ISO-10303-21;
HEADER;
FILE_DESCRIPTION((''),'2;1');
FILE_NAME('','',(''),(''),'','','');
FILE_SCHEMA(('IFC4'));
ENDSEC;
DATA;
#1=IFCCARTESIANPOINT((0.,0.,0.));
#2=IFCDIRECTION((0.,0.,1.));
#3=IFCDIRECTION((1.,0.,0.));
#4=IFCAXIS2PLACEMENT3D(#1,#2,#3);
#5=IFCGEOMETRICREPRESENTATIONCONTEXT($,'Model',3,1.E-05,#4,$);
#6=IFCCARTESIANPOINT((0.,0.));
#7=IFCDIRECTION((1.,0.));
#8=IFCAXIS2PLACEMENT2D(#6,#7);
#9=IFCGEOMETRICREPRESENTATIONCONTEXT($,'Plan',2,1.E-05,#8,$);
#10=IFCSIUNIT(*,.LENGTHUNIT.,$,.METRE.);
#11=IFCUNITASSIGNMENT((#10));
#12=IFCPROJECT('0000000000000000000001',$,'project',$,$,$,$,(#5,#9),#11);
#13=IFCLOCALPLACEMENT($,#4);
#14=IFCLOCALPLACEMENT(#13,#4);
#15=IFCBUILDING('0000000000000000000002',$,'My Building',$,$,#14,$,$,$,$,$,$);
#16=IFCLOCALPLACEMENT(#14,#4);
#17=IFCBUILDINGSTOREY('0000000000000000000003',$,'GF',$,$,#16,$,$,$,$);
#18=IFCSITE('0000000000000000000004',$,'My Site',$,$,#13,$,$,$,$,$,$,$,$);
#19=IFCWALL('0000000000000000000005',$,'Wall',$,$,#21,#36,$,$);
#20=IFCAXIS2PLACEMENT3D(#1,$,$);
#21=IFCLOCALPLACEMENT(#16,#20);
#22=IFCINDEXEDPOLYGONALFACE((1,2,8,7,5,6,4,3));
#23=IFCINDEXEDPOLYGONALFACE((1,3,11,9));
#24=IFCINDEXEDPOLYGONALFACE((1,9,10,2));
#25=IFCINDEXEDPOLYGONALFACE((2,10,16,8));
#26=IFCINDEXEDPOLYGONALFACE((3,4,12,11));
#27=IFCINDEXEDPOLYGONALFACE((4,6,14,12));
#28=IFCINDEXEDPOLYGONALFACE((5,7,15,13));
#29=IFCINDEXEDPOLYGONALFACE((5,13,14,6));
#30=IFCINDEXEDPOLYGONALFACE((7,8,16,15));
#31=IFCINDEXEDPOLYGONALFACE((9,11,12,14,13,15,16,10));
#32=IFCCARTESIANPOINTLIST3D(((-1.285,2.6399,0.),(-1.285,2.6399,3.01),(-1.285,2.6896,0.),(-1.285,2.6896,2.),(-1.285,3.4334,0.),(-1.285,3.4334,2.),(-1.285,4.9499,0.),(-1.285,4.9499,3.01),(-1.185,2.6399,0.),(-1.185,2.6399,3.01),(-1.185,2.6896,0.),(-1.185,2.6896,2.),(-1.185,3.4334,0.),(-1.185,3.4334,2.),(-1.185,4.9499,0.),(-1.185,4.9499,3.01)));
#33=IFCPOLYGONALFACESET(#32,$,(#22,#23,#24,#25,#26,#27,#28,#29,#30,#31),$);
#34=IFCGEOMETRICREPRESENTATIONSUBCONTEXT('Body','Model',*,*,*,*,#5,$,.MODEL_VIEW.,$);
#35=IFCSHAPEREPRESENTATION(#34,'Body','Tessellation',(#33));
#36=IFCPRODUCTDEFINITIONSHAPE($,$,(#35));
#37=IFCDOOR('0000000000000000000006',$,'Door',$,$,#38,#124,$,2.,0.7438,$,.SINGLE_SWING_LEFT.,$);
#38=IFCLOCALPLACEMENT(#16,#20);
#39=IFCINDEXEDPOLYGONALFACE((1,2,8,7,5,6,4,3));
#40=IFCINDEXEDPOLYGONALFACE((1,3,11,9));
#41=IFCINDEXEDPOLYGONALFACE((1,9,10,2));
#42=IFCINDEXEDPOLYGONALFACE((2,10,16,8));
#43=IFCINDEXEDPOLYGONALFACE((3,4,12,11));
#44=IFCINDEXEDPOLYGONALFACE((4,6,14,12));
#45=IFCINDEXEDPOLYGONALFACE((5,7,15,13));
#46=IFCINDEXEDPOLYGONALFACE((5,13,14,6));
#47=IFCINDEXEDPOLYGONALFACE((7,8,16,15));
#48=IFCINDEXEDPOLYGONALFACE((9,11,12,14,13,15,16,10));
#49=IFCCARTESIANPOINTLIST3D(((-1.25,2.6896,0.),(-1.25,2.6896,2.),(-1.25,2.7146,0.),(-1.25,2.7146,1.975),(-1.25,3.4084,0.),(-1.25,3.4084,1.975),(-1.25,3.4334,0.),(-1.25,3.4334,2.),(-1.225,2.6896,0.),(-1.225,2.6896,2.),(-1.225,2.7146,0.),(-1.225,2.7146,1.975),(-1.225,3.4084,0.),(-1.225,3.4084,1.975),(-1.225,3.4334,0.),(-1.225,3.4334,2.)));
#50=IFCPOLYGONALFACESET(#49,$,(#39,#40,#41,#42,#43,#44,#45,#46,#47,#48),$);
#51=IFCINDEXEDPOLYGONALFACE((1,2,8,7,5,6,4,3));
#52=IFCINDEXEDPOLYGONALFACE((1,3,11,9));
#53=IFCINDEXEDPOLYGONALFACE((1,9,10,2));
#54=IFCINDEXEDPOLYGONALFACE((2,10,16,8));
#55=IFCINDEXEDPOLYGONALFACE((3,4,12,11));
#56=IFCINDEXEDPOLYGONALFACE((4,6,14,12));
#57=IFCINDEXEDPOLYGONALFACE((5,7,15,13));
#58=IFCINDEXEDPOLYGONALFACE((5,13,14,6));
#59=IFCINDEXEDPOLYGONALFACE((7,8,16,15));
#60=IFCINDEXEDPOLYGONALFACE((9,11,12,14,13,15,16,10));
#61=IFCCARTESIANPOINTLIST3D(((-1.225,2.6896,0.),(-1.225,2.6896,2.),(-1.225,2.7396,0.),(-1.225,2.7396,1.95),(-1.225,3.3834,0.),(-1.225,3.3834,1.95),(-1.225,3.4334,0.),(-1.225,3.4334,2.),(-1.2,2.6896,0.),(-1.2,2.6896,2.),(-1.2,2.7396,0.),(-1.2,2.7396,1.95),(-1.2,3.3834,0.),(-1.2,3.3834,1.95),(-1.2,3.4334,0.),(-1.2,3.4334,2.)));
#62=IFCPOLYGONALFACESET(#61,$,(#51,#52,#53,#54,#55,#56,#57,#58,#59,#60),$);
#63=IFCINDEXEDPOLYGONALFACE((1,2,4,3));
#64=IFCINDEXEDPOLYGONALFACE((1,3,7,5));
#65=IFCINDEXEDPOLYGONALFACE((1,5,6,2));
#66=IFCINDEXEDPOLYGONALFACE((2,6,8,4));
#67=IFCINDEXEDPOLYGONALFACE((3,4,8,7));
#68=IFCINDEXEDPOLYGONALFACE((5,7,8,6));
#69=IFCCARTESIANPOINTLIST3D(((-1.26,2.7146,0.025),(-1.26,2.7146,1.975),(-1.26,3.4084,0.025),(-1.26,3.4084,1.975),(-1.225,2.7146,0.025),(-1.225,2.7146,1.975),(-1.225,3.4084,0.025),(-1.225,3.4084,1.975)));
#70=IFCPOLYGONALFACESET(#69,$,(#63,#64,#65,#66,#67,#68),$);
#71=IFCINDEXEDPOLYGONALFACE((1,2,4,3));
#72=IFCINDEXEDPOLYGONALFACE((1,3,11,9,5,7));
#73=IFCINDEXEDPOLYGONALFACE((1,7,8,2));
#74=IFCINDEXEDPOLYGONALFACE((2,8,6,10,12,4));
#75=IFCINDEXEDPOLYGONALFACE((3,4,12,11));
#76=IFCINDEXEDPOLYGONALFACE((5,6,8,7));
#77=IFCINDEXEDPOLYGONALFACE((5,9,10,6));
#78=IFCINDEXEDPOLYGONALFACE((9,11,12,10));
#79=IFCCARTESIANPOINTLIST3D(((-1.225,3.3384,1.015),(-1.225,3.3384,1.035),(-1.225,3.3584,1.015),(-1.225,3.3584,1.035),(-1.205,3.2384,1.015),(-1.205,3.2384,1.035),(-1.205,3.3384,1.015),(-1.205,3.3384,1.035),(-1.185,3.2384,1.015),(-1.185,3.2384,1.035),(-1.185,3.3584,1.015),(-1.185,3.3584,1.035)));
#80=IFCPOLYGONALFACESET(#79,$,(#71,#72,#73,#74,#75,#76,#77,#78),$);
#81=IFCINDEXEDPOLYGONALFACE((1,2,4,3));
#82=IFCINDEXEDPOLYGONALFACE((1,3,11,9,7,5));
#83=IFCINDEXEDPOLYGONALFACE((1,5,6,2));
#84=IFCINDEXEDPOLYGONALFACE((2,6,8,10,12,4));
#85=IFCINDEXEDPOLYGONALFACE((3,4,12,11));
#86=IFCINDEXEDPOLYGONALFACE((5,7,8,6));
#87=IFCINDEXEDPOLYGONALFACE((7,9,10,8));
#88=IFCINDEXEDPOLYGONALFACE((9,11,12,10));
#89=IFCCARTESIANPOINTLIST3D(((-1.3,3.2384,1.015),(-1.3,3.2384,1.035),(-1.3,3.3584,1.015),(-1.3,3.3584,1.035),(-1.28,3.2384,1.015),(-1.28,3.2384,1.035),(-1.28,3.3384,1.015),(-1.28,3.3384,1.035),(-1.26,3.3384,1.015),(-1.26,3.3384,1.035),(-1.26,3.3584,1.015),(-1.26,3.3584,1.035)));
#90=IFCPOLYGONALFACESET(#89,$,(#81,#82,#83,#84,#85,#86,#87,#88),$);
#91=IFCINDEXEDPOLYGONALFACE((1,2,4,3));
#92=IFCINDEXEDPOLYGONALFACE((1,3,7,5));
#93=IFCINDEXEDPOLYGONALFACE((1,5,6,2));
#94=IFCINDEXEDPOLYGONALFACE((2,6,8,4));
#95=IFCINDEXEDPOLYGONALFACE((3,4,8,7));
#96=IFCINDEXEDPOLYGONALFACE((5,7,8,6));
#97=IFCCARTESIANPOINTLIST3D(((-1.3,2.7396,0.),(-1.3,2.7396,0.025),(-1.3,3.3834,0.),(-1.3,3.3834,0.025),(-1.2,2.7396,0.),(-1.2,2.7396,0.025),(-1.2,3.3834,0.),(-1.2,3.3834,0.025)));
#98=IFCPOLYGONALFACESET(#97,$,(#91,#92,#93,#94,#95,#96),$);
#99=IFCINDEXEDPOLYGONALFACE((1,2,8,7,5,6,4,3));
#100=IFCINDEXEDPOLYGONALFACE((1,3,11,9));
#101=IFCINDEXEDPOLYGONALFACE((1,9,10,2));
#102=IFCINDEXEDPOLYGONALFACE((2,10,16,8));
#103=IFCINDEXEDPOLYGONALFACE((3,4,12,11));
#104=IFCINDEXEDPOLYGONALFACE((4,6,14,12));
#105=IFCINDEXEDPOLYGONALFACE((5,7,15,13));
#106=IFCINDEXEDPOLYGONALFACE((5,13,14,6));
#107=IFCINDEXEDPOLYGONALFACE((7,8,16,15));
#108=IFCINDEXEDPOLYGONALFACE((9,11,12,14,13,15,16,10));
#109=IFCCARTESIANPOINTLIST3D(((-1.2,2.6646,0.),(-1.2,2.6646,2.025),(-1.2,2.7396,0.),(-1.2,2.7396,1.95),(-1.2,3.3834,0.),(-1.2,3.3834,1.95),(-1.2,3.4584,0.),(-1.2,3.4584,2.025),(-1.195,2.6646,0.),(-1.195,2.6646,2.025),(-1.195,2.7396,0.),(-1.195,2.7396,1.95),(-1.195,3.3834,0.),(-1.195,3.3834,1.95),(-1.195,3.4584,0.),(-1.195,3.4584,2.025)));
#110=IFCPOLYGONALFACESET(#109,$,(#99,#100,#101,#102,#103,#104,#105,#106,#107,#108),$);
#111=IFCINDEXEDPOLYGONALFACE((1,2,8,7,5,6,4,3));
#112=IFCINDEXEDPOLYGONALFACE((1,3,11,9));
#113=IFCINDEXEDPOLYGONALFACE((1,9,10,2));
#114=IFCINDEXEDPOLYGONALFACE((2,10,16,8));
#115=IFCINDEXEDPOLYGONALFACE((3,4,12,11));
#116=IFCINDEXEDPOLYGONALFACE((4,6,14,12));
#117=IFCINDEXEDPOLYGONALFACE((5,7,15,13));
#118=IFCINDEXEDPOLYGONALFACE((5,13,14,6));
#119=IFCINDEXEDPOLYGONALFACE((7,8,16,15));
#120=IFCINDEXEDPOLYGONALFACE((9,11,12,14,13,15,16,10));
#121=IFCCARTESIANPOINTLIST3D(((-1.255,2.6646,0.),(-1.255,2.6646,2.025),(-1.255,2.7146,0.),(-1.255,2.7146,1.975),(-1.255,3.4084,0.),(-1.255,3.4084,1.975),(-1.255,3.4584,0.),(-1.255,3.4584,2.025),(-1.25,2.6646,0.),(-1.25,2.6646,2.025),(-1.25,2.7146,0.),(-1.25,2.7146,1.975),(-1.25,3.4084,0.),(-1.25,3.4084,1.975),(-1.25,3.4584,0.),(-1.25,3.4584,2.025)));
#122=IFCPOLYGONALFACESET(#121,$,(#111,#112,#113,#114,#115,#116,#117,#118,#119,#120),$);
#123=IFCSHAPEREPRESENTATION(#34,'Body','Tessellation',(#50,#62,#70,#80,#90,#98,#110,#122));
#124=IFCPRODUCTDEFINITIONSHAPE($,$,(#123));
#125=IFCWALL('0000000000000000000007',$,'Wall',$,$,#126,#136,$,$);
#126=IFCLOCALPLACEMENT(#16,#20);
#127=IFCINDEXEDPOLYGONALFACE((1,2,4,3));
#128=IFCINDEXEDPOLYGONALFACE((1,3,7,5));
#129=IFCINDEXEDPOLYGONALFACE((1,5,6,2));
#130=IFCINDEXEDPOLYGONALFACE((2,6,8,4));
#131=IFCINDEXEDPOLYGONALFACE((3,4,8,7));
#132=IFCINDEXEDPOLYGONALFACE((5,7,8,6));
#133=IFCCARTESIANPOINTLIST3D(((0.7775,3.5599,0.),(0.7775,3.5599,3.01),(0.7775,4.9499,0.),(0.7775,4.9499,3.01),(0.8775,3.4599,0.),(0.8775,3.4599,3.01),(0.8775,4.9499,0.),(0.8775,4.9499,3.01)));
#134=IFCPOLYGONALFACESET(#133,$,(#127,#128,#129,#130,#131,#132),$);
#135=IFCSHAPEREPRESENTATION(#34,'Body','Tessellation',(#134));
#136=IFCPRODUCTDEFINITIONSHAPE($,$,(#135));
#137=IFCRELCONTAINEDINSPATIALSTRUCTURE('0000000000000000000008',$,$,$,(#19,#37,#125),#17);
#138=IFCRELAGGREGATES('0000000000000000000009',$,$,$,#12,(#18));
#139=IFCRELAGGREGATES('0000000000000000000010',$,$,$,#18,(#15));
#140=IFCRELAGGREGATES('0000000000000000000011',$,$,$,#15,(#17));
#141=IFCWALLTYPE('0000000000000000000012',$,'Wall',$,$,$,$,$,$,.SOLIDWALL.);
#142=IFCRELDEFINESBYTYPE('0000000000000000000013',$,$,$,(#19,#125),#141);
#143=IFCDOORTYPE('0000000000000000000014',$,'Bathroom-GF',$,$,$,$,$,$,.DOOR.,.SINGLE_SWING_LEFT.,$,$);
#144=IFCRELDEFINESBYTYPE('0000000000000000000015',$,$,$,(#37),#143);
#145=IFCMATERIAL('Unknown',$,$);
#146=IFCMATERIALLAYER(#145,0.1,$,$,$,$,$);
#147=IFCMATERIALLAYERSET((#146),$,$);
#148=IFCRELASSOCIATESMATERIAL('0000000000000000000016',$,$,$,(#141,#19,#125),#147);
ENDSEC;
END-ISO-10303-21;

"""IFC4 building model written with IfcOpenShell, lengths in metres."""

from ifc_helpers import new_model, entity, si_unit, frame, origin_with_axes, origin_2d_with_axis, place, context, subcontext, project, spatial, line, indexed_curve, outline, extrude, shape, source, transform, mapped, material, layer, layer_set, layer_usage, type_object, type_shapes, element, fill, save


model = new_model("IFC4")

# Units and contexts
model_context = context("Model", 3, precision=1e-05, world=origin_with_axes())
plan_context = context("Plan", 2, precision=1e-05, world=origin_2d_with_axis())
body_context_1 = subcontext(model_context, "Body", "Model", "MODEL_VIEW")
body_context_2 = subcontext(plan_context, "Body", "Plan", "PLAN_VIEW")
ifc_project = project(units=[si_unit("LENGTHUNIT", "METRE")], contexts=[model_context, plan_context])

# Site, building, storey
site_placement = place(None, origin_with_axes())
site = spatial("IfcSite", under=ifc_project, at=site_placement, Name="My Site")
building_placement = place(site_placement, origin_with_axes())
building = spatial("IfcBuilding", under=site, at=building_placement, Name="My Building")
storey_placement = place(building_placement, origin_with_axes())
storey = spatial("IfcBuildingStorey", under=building, at=storey_placement, Name="GF")

# Shared definitions
ifc_material = material(Name="Unknown")

# Shared definitions
ifc_layer_1 = layer(ifc_material, 0.1)
ifc_layer_set_1 = layer_set([ifc_layer_1])
wall_type = type_object("IfcWallType", Name="Wall", PredefinedType="SOLIDWALL", material=ifc_layer_set_1)

# Wall, opening, door
ifc_layer_usage_1 = layer_usage(ifc_layer_set_1, "AXIS2", "POSITIVE", 0.0)
wall_1_placement = place(storey_placement, frame((-1.185, 2.6399, 0.0), z_axis=(0.0, 0.0, 1.0), x_axis=(0.0, 1.0, 0.0)))
wall_1 = element("IfcWall", 1, at=wall_1_placement, inside=storey, type_object=wall_type, material=ifc_layer_usage_1, Name="Wall", context=body_context_1, shape_type="SweptSolid", body=[
    extrude(outline(indexed_curve([(0.0, 0.0), (0.0, 0.1), (2.31, 0.1), (2.31, 0.0)], segments=[line(1, 2, 3, 4, 1)])), origin_with_axes(), (0.0, 0.0, 1.0), 3.01),
])
shared_shape_1 = source(origin_with_axes(), body_context_1, "Body", "SweptSolid", [
    extrude(outline(indexed_curve([(0.0, 0.0), (0.7438, 0.0), (0.7438, 2.0), (0.0, 2.0)], segments=[line(1, 2, 3, 4, 1)])), frame((0.0, -0.6, 0.0), z_axis=(0.0, -1.0, 0.0), x_axis=(1.0, 0.0, 0.0)), (0.0, 0.0, -1.0), 1.2),
])
opening_1_placement = place(wall_1_placement, frame((0.0497, 0.015, 0.0), z_axis=(0.0, 0.0, 1.0), x_axis=(1.0, 0.0, 0.0)))
opening_1 = element("IfcOpeningElement", 2, at=opening_1_placement, cuts=wall_1, PredefinedType="OPENING", context=body_context_1, shape_type="MappedRepresentation", body=[
    mapped(shared_shape_1, transform((0.0, 0.0, 0.0), x_axis=(1.0, 0.0, 0.0), y_axis=(0.0, 1.0, 0.0), z_axis=(0.0, 0.0, 1.0), scale=1.0)),
])
door_type_1 = type_object("IfcDoorType", Name="Bathroom-GF", OperationType="SINGLE_SWING_LEFT", PredefinedType="DOOR")
shared_shape_2 = source(origin_with_axes(), body_context_1, "Body", "SweptSolid", [
    extrude(outline(indexed_curve([(0.0, 0.0), (0.0, 2.0), (0.7438, 2.0), (0.7438, 0.0), (0.7188, 0.0), (0.7188, 1.975), (0.025, 1.975), (0.025, 0.0)], segments=[line(1, 2, 3, 4, 5, 6, 7, 8, 1)])), frame((0.0, 0.025, 0.0), z_axis=(0.0, -1.0, 0.0), x_axis=(1.0, 0.0, 0.0)), (0.0, 0.0, -1.0), 0.025),
    extrude(outline(indexed_curve([(0.0, 0.0), (0.0, 2.0), (0.7438, 2.0), (0.7438, 0.0), (0.6938, 0.0), (0.6938, 1.95), (0.05, 1.95), (0.05, 0.0)], segments=[line(1, 2, 3, 4, 5, 6, 7, 8, 1)])), frame((0.0, 0.0, 0.0), z_axis=(0.0, -1.0, 0.0), x_axis=(1.0, 0.0, 0.0)), (0.0, 0.0, -1.0), 0.025),
    extrude(outline(indexed_curve([(0.0, 0.0), (0.6938, 0.0), (0.6938, 0.035), (0.0, 0.035)], segments=[line(1, 2, 3, 4, 1)])), frame((0.025, 0.025, 0.025), z_axis=(0.0, 0.0, 1.0), x_axis=(1.0, 0.0, 0.0)), (0.0, 0.0, 1.0), 1.95),
    extrude(outline(indexed_curve([(0.0, 0.0), (0.0, -0.04), (-0.12, -0.04), (-0.12, -0.02), (-0.02, -0.02), (-0.02, 0.0)], segments=[line(1, 2, 3, 4, 5, 6, 1)])), frame((0.6688, 0.025, 1.015), z_axis=(0.0, 0.0, 1.0), x_axis=(1.0, 0.0, 0.0)), (0.0, 0.0, 1.0), 0.02),
    extrude(outline(indexed_curve([(0.0, 0.0), (0.0, 0.04), (-0.12, 0.04), (-0.12, 0.02), (-0.02, 0.02), (-0.02, 0.0)], segments=[line(1, 2, 3, 4, 5, 6, 1)])), frame((0.6688, 0.06, 1.015), z_axis=(0.0, 0.0, 1.0), x_axis=(1.0, 0.0, 0.0)), (0.0, 0.0, 1.0), 0.02),
    extrude(outline(indexed_curve([(0.0, 0.0), (0.6438, 0.0), (0.6438, 0.1), (0.0, 0.1)], segments=[line(1, 2, 3, 4, 1)])), frame((0.05, 0.0, 0.0), z_axis=(0.0, 0.0, 1.0), x_axis=(1.0, 0.0, 0.0)), (0.0, 0.0, 1.0), 0.025),
    extrude(outline(indexed_curve([(0.0, 0.0), (0.0, 2.025), (0.7938, 2.025), (0.7938, 0.0), (0.7188, 0.0), (0.7188, 1.95), (0.075, 1.95), (0.075, 0.0)], segments=[line(1, 2, 3, 4, 5, 6, 7, 8, 1)])), frame((-0.025, -0.005, 0.0), z_axis=(0.0, -1.0, 0.0), x_axis=(1.0, 0.0, 0.0)), (0.0, 0.0, -1.0), 0.005),
    extrude(outline(indexed_curve([(0.0, 0.0), (0.0, 2.025), (0.7938, 2.025), (0.7938, 0.0), (0.7438, 0.0), (0.7438, 1.975), (0.05, 1.975), (0.05, 0.0)], segments=[line(1, 2, 3, 4, 5, 6, 7, 8, 1)])), frame((-0.025, 0.05, 0.0), z_axis=(0.0, -1.0, 0.0), x_axis=(1.0, 0.0, 0.0)), (0.0, 0.0, -1.0), 0.005),
])
shared_shape_3 = source(origin_with_axes(), body_context_2, "Body", "Curve2D", [
    entity("IfcIndexedPolyCurve", entity("IfcCartesianPointList2D", [[0.0, 0.0], [0.0, 0.05], [0.025, 0.05], [0.025, 0.025], [0.05, 0.025], [0.05, 0.0]]), [entity("IfcLineIndex", [1, 2, 3, 4, 5, 6, 1])]),
    entity("IfcIndexedPolyCurve", entity("IfcCartesianPointList2D", [[0.7438, 0.0], [0.7438, 0.05], [0.7188, 0.05], [0.7188, 0.025], [0.6938, 0.025], [0.6938, 0.0]]), [entity("IfcLineIndex", [1, 2, 3, 4, 5, 6, 1])]),
    entity("IfcTrimmedCurve", entity("IfcEllipse", entity("IfcAxis2Placement2D", entity("IfcCartesianPoint", [0.06, 0.05]), entity("IfcDirection", [1.0, 0.0])), 0.6588, 0.6938), [entity("IfcCartesianPoint", [0.7188, 0.05])], [entity("IfcCartesianPoint", [0.06, 0.7438])], True, "CARTESIAN"),
    entity("IfcIndexedPolyCurve", entity("IfcCartesianPointList2D", [[0.025, 0.05], [0.06, 0.05], [0.06, 0.7438], [0.025, 0.7438]]), [entity("IfcLineIndex", [1, 2, 3, 4, 1])]),
])
type_shapes(door_type_1, [shared_shape_2, shared_shape_3])
door_1_placement = place(opening_1_placement, frame((0.0, 0.0, 0.0), z_axis=(0.0, 0.0, 1.0), x_axis=(1.0, 0.0, 0.0)))
door_1 = element("IfcDoor", 3, at=door_1_placement, inside=storey, type_object=door_type_1, Name="Door", OperationType="SINGLE_SWING_LEFT", OverallHeight=2.0, OverallWidth=0.7438, shapes=[
    shape(body_context_1, "Body", "MappedRepresentation", [mapped(shared_shape_2, transform((0.0, 0.0, 0.0), x_axis=(1.0, 0.0, 0.0), y_axis=(0.0, 1.0, 0.0), z_axis=(0.0, 0.0, 1.0), scale=1.0))]),
    shape(body_context_2, "Body", "MappedRepresentation", [mapped(shared_shape_3, transform((0.0, 0.0, 0.0), x_axis=(1.0, 0.0, 0.0), y_axis=(0.0, 1.0, 0.0), z_axis=(0.0, 0.0, 1.0), scale=1.0))]),
])
fill(opening_1, door_1)

# Wall
ifc_layer_usage_2 = layer_usage(ifc_layer_set_1, "AXIS2", "POSITIVE", 0.0)
wall_2_placement = place(storey_placement, frame((0.7775, 4.9499, 0.0), z_axis=(0.0, 0.0, 1.0), x_axis=(0.0, -1.0, 0.0)))
element("IfcWall", 4, at=wall_2_placement, inside=storey, type_object=wall_type, material=ifc_layer_usage_2, Name="Wall", context=body_context_1, shape_type="SweptSolid", body=[
    extrude(outline(indexed_curve([(0.0, 0.0), (0.0, 0.1), (1.49, 0.1), (1.39, 0.0)], segments=[line(1, 2, 3, 4, 1)])), origin_with_axes(), (0.0, 0.0, 1.0), 3.01),
])

save(model, "model.ifc")
